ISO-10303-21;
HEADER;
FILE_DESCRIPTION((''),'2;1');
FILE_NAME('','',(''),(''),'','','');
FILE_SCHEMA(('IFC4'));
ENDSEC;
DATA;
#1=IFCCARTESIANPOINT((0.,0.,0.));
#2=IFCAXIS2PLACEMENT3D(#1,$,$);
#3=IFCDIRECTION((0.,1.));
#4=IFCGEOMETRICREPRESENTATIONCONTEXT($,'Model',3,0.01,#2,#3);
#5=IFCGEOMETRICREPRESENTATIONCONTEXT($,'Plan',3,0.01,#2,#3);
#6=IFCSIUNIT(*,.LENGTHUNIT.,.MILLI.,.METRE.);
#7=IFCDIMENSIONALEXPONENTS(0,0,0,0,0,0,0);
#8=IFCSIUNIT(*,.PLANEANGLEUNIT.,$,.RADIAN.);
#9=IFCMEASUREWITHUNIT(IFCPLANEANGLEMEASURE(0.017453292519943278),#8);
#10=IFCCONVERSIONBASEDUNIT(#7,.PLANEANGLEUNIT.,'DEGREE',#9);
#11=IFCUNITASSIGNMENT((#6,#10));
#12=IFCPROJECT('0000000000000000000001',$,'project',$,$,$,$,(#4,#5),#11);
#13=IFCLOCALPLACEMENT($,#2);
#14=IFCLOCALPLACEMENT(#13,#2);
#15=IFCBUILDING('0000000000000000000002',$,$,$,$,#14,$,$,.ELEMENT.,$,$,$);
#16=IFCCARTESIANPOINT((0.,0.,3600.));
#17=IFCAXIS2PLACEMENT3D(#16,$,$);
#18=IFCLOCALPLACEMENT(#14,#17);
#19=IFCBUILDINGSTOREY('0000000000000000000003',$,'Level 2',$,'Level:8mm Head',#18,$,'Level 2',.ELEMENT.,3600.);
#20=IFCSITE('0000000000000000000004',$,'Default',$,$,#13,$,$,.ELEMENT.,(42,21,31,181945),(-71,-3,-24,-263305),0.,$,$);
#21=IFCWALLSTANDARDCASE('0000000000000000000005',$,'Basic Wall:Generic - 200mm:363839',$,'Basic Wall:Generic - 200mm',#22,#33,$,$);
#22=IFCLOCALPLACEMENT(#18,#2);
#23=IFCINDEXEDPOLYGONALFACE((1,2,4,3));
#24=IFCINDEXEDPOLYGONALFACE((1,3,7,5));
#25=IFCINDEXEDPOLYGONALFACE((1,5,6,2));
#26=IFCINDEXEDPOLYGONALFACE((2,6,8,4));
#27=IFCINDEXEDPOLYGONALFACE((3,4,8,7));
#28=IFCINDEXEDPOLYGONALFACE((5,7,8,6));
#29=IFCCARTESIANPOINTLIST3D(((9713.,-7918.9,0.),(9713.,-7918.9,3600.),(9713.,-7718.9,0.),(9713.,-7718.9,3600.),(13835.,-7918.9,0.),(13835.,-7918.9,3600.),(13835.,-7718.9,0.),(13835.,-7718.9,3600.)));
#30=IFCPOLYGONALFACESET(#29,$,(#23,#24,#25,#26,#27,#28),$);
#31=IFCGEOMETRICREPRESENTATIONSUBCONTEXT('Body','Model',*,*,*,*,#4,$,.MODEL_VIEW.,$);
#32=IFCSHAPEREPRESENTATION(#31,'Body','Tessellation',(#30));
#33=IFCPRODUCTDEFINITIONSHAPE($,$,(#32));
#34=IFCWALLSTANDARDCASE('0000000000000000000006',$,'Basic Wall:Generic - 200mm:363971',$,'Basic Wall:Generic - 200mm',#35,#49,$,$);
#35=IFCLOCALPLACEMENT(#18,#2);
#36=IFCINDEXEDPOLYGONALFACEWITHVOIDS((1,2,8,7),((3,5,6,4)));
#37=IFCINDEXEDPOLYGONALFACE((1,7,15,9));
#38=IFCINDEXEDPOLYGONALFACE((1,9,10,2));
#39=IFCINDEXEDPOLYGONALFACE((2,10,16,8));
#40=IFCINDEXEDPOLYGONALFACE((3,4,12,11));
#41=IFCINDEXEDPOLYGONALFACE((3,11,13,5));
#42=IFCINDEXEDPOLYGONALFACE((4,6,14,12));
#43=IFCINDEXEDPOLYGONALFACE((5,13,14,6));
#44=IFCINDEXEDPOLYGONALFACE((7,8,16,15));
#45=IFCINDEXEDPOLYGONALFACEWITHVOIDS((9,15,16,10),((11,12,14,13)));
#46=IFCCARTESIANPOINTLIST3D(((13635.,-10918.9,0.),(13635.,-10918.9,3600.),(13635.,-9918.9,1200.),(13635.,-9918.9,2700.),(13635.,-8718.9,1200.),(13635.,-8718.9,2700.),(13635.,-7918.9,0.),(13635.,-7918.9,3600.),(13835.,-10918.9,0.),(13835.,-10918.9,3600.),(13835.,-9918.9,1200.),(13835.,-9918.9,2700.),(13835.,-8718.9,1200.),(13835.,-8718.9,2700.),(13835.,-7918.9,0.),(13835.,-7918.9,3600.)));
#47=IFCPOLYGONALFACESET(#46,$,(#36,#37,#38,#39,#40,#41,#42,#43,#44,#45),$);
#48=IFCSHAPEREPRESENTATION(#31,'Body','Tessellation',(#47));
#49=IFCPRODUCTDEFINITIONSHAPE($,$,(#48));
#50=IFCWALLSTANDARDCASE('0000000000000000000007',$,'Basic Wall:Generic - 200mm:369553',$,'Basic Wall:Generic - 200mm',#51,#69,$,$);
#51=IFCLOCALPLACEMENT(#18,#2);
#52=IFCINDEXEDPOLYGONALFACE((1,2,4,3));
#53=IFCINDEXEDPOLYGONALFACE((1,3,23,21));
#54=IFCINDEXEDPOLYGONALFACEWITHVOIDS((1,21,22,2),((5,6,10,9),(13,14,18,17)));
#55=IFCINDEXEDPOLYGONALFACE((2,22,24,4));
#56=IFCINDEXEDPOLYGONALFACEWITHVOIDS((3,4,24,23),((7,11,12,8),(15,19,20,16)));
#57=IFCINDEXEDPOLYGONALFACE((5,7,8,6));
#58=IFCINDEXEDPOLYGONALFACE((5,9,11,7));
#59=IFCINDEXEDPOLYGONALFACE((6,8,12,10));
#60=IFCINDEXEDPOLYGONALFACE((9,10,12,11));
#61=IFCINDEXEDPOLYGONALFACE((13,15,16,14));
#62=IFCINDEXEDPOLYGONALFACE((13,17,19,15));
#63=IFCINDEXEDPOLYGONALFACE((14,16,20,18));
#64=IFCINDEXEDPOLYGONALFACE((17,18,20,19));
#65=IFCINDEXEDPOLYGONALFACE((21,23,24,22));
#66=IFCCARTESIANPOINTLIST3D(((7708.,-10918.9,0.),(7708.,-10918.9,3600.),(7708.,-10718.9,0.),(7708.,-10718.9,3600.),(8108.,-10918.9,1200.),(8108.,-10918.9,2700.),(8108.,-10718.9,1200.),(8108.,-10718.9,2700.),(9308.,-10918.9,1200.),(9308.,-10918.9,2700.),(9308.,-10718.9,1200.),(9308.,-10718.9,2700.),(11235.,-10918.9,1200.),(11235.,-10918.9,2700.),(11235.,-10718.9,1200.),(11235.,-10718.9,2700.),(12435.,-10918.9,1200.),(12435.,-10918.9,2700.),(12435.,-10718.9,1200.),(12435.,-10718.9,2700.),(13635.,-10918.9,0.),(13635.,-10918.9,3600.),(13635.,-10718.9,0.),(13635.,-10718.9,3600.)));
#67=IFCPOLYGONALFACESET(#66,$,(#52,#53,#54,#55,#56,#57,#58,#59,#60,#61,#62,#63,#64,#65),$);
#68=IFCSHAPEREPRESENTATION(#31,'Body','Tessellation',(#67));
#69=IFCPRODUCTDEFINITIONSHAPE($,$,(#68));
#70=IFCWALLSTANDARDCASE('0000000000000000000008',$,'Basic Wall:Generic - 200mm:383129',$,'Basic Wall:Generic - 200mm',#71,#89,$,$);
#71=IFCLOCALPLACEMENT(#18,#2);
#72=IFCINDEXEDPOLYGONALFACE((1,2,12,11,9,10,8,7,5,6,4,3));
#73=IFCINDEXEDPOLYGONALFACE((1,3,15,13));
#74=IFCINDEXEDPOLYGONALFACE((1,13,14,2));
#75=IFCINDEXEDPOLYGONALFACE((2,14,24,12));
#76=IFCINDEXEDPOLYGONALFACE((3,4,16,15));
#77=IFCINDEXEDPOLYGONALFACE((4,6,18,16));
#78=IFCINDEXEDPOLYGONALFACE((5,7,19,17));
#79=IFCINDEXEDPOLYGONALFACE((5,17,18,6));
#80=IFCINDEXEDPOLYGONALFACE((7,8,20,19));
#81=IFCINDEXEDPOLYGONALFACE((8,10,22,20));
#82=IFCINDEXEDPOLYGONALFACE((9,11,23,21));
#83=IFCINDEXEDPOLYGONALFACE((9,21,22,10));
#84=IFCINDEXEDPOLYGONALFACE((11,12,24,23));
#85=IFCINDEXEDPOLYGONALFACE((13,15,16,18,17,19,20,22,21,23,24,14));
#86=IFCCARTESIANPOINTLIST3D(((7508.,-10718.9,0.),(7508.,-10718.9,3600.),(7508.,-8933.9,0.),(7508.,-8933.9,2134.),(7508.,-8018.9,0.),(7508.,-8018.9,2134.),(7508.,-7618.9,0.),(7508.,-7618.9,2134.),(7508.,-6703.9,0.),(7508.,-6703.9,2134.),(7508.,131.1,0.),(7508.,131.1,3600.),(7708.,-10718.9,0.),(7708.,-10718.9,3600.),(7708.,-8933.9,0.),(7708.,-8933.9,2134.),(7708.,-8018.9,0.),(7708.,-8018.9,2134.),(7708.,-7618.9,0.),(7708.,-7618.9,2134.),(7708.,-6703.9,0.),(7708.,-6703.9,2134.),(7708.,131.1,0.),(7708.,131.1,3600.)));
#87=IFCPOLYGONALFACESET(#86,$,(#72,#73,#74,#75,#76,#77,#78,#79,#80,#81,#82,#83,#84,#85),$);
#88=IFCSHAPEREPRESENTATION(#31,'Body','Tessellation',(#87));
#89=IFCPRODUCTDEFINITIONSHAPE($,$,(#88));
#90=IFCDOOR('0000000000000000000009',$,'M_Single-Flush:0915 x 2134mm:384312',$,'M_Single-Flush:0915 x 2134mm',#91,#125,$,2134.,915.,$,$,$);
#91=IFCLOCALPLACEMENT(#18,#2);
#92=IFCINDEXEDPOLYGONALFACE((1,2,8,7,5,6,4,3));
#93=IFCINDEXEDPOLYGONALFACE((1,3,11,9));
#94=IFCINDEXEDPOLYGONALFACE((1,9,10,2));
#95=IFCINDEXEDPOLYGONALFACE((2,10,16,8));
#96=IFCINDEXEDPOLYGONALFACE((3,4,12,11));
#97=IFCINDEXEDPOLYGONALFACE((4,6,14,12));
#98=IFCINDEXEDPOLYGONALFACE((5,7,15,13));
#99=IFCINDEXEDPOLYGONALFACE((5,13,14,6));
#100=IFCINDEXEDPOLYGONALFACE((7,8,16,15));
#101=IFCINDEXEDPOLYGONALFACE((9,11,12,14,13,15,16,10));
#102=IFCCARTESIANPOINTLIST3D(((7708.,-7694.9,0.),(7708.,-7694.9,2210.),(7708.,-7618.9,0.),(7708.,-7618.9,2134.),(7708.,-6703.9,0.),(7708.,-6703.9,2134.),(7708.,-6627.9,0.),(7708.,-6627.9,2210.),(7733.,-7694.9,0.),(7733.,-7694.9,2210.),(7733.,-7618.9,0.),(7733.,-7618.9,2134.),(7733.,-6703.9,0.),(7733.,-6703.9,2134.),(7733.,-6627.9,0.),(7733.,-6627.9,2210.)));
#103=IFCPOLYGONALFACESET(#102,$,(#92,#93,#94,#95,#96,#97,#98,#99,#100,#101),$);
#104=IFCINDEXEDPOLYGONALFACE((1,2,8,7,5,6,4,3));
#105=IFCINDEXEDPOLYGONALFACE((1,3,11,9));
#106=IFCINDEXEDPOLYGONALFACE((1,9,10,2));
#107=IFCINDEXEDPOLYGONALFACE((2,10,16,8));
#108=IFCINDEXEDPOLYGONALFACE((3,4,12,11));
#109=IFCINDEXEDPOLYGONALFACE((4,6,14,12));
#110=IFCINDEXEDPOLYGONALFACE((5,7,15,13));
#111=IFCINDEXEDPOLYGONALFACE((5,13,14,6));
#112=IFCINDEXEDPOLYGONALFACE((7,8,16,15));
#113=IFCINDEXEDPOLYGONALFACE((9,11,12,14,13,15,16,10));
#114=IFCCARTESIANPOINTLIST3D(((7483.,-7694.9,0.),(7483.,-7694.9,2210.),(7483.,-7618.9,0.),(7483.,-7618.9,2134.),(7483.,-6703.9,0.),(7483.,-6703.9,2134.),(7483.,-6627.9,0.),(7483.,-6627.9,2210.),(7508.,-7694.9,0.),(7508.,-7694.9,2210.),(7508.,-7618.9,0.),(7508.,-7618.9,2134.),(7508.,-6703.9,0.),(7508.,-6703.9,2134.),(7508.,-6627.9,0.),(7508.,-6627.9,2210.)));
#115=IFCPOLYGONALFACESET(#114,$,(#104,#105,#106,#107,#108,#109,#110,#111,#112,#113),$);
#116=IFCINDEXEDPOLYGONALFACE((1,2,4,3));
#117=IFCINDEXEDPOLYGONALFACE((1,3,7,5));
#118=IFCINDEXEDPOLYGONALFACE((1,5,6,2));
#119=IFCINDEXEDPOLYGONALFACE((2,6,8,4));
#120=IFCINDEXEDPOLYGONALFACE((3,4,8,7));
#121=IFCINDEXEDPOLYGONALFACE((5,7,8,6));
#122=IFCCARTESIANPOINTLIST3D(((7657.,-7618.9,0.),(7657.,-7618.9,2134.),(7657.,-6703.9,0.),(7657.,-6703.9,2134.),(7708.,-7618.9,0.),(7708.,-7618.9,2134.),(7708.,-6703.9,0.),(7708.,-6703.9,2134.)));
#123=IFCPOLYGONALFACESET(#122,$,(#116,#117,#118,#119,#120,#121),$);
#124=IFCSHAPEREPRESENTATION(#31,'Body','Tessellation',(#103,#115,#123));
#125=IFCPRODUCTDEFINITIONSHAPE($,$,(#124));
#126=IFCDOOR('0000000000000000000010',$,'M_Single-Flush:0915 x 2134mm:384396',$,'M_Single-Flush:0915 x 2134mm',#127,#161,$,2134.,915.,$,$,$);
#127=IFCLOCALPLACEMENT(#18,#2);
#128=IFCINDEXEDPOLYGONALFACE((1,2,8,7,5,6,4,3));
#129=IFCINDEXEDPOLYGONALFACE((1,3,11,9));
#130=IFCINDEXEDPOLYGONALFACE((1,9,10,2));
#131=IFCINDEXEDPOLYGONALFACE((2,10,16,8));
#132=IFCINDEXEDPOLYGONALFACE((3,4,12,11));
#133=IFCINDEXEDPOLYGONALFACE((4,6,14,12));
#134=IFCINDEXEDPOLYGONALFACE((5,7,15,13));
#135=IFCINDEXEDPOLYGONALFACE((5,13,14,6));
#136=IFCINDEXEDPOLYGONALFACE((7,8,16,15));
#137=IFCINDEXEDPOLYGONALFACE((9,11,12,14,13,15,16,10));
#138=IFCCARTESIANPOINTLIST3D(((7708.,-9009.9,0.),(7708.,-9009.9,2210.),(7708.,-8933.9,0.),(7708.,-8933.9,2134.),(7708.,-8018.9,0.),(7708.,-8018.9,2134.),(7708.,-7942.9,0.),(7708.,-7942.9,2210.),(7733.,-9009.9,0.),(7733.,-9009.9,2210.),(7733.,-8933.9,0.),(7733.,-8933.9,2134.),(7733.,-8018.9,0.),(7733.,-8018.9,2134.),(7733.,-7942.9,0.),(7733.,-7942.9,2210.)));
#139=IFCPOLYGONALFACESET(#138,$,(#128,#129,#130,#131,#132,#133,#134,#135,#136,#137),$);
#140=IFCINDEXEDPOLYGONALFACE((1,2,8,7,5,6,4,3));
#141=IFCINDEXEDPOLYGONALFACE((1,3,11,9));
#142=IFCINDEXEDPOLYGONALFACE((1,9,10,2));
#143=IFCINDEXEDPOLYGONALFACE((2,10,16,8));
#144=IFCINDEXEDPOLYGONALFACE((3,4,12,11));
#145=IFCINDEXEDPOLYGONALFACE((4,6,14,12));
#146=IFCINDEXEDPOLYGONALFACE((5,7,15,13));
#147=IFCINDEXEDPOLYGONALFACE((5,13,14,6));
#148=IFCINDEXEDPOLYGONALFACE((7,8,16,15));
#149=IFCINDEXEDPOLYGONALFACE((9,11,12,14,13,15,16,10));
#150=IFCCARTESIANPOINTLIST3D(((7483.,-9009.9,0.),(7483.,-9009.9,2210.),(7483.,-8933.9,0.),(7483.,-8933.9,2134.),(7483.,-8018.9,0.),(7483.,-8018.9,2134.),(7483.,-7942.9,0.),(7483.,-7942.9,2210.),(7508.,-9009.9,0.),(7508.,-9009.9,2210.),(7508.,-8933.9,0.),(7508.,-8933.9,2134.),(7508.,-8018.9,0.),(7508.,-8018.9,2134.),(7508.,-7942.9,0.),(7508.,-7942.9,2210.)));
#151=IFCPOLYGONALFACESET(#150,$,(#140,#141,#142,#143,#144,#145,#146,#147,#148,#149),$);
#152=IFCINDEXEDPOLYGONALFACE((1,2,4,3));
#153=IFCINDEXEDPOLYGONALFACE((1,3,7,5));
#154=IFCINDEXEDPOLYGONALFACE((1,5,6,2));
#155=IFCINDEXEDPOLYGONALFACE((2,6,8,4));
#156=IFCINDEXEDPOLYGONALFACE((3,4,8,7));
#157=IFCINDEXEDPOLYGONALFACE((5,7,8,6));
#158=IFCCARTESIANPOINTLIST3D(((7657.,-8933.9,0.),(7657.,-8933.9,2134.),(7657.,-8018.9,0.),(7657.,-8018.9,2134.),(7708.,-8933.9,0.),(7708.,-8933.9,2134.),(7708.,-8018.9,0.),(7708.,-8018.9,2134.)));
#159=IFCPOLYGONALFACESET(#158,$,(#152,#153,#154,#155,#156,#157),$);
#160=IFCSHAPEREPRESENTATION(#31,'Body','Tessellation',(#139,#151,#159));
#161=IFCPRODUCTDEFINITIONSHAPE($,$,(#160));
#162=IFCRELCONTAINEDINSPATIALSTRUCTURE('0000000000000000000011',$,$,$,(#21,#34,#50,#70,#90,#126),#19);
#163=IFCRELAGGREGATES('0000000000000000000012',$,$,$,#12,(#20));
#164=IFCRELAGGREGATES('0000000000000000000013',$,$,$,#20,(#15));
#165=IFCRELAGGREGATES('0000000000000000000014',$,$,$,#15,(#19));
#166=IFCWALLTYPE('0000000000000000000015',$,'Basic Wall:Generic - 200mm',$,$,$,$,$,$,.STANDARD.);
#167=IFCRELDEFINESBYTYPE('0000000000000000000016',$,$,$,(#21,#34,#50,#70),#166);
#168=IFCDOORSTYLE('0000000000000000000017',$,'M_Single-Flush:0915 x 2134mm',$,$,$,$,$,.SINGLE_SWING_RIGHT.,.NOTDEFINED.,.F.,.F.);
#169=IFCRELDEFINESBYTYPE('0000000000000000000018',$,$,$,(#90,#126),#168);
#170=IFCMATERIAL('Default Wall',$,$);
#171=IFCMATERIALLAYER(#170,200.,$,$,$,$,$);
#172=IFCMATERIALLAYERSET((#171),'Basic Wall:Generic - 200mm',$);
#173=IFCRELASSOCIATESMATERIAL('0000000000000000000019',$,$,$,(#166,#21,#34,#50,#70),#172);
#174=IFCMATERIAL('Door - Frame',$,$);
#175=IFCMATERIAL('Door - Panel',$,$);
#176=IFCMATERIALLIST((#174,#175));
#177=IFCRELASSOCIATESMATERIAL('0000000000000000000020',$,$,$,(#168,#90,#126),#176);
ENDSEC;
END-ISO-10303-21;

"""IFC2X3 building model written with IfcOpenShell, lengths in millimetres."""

from ifc_helpers import new_model, entity, si_unit, converted_unit, direction, frame, frame_2d, origin, place, context, subcontext, project, spatial, polyline, rectangle, outline, extrude, source, transform, mapped, material, material_list, layer, layer_set, layer_usage, type_object, type_shapes, element, fill, save


model = new_model("IFC2X3")

# Units and contexts
model_context = context("Model", 3, precision=0.01, world=origin(), true_north=direction((0.0, 1.0)))
plan_context = context("Plan", 3, precision=0.01, world=origin(), true_north=direction((0.0, 1.0)))
body_context = subcontext(model_context, "Body", "Model", "MODEL_VIEW")
ifc_project = project(units=[si_unit("LENGTHUNIT", "METRE", prefix="MILLI"), converted_unit("PLANEANGLEUNIT", "DEGREE", entity("IfcPlaneAngleMeasure", 0.017453292519943278), si_unit("PLANEANGLEUNIT", "RADIAN"), dimensions=[0, 0, 0, 0, 0, 0, 0])], contexts=[model_context, plan_context])

# Site, building, storey
site_placement = place(None, origin())
site = spatial("IfcSite", under=ifc_project, at=site_placement, Name="Default", CompositionType="ELEMENT", RefLatitude=(42, 21, 31, 181945), RefLongitude=(-71, -3, -24, -263305), RefElevation=0.0)
building_placement = place(site_placement, origin())
building = spatial("IfcBuilding", under=site, at=building_placement, CompositionType="ELEMENT")
storey_placement = place(building_placement, frame((0.0, 0.0, 3600.0)))
storey = spatial("IfcBuildingStorey", under=building, at=storey_placement, Name="Level 2", ObjectType="Level:8mm Head", LongName="Level 2", CompositionType="ELEMENT", Elevation=3600.0)

# Wall
ifc_material_1 = material(Name="Default Wall")
ifc_layer = layer(ifc_material_1, 200.0)
ifc_layer_set = layer_set([ifc_layer], Name="Basic Wall:Generic - 200mm")
ifc_layer_usage_1 = layer_usage(ifc_layer_set, "AXIS2", "NEGATIVE", 100.0)
wall_type = type_object("IfcWallType", Name="Basic Wall:Generic - 200mm", PredefinedType="STANDARD", material=ifc_layer_set)
wall_1_placement = place(storey_placement, frame((9713.0, -7818.9, 0.0)))
element("IfcWallStandardCase", 1, at=wall_1_placement, inside=storey, type_object=wall_type, material=ifc_layer_usage_1, Name="Basic Wall:Generic - 200mm:363839", ObjectType="Basic Wall:Generic - 200mm", context=body_context, shape_type="SweptSolid", body=[
    extrude(rectangle(XDim=4122.0, YDim=200.0, at=frame_2d((2061.0, 0.0), x_axis=(-1.0, 0.0))), origin(), (0.0, 0.0, 1.0), 3600.0),
])

# Wall, opening
ifc_layer_usage_2 = layer_usage(ifc_layer_set, "AXIS2", "NEGATIVE", 100.0)
wall_2_placement = place(storey_placement, frame((13735.0, -7918.9, 0.0), z_axis=(0.0, 0.0, 1.0), x_axis=(0.0, -1.0, 0.0)))
wall_2 = element("IfcWallStandardCase", 2, at=wall_2_placement, inside=storey, type_object=wall_type, material=ifc_layer_usage_2, Name="Basic Wall:Generic - 200mm:363971", ObjectType="Basic Wall:Generic - 200mm", context=body_context, shape_type="SweptSolid", body=[
    extrude(rectangle(XDim=3000.0, YDim=200.0, at=frame_2d((1500.0, 0.0), x_axis=(-1.0, 0.0))), origin(), (0.0, 0.0, 1.0), 3600.0),
])
opening_1_placement = place(wall_2_placement, frame((800.0, -100.0, 1200.0)))
element("IfcOpeningElement", 3, at=opening_1_placement, cuts=wall_2, ObjectType="Opening", context=body_context, shape_type="SweptSolid", body=[
    extrude(rectangle(XDim=1500.0, YDim=1200.0, at=frame_2d((750.0, 600.0), x_axis=(-1.0, 0.0))), frame((0.0, 0.0, 0.0), z_axis=(0.0, 1.0, 0.0), x_axis=(0.0, 0.0, 1.0)), (0.0, 0.0, 1.0), 200.0),
])

# Wall, openings
ifc_layer_usage_3 = layer_usage(ifc_layer_set, "AXIS2", "NEGATIVE", 100.0)
wall_3_placement = place(storey_placement, frame((7708.0, -10818.9, 0.0)))
wall_3 = element("IfcWallStandardCase", 4, at=wall_3_placement, inside=storey, type_object=wall_type, material=ifc_layer_usage_3, Name="Basic Wall:Generic - 200mm:369553", ObjectType="Basic Wall:Generic - 200mm", context=body_context, shape_type="SweptSolid", body=[
    extrude(rectangle(XDim=5927.0, YDim=200.0, at=frame_2d((2963.5, 0.0), x_axis=(-1.0, 0.0))), origin(), (0.0, 0.0, 1.0), 3600.0),
])
opening_2_placement = place(wall_3_placement, frame((1600.0, 100.0, 1200.0)))
element("IfcOpeningElement", 5, at=opening_2_placement, cuts=wall_3, ObjectType="Opening", context=body_context, shape_type="SweptSolid", body=[
    extrude(rectangle(XDim=1500.0, YDim=1200.0, at=frame_2d((750.0, 600.0), x_axis=(-1.0, 0.0))), frame((0.0, 0.0, 0.0), z_axis=(0.0, -1.0, 0.0), x_axis=(0.0, 0.0, 1.0)), (0.0, 0.0, 1.0), 200.0),
])
opening_3_placement = place(wall_3_placement, frame((4727.0, 100.0, 1200.0)))
element("IfcOpeningElement", 6, at=opening_3_placement, cuts=wall_3, ObjectType="Opening", context=body_context, shape_type="SweptSolid", body=[
    extrude(rectangle(XDim=1500.0, YDim=1200.0, at=frame_2d((750.0, 600.0), x_axis=(-1.0, 0.0))), frame((0.0, 0.0, 0.0), z_axis=(0.0, -1.0, 0.0), x_axis=(0.0, 0.0, 1.0)), (0.0, 0.0, 1.0), 200.0),
])

# Wall, openings, doors
ifc_layer_usage_4 = layer_usage(ifc_layer_set, "AXIS2", "NEGATIVE", 100.0)
wall_4_placement = place(storey_placement, frame((7608.0, -10718.9, 0.0), z_axis=(0.0, 0.0, 1.0), x_axis=(0.0, 1.0, 0.0)))
wall_4 = element("IfcWallStandardCase", 7, at=wall_4_placement, inside=storey, type_object=wall_type, material=ifc_layer_usage_4, Name="Basic Wall:Generic - 200mm:383129", ObjectType="Basic Wall:Generic - 200mm", context=body_context, shape_type="SweptSolid", body=[
    extrude(rectangle(XDim=10850.0, YDim=200.0, at=frame_2d((5425.0, 0.0), x_axis=(1.0, 0.0))), origin(), (0.0, 0.0, 1.0), 3600.0),
])
opening_4_placement = place(wall_4_placement, frame((4015.0, 100.0, 0.0)))
opening_4 = element("IfcOpeningElement", 8, at=opening_4_placement, cuts=wall_4, ObjectType="Opening", context=body_context, shape_type="SweptSolid", body=[
    extrude(rectangle(XDim=915.0, YDim=2134.0, at=frame_2d((1067.0, 457.5), x_axis=(0.0, 1.0))), frame((0.0, 0.0, 0.0), z_axis=(0.0, -1.0, 0.0), x_axis=(0.0, 0.0, 1.0)), (0.0, 0.0, 1.0), 200.0),
])
opening_5_placement = place(wall_4_placement, frame((2700.0, 100.0, 0.0)))
opening_5 = element("IfcOpeningElement", 9, at=opening_5_placement, cuts=wall_4, ObjectType="Opening", context=body_context, shape_type="SweptSolid", body=[
    extrude(rectangle(XDim=915.0, YDim=2134.0, at=frame_2d((1067.0, 457.5), x_axis=(0.0, 1.0))), frame((0.0, 0.0, 0.0), z_axis=(0.0, -1.0, 0.0), x_axis=(0.0, 0.0, 1.0)), (0.0, 0.0, 1.0), 200.0),
])
ifc_material_2 = material(Name="Door - Frame")
ifc_material_3 = material(Name="Door - Panel")
ifc_material_list_1 = material_list([ifc_material_2, ifc_material_3])
door_style = type_object("IfcDoorStyle", Name="M_Single-Flush:0915 x 2134mm", ConstructionType="NOTDEFINED", OperationType="SINGLE_SWING_RIGHT", ParameterTakesPrecedence=False, Sizeable=False, material=ifc_material_list_1)
shared_shape_1 = source(origin(), body_context, "Body", "SweptSolid", [
    extrude(outline(polyline([(-533.5, -1124.0), (533.5, -1124.0), (533.5, 1086.0), (457.5, 1086.0), (457.5, -1048.0), (-457.5, -1048.0), (-457.5, 1086.0), (-533.5, 1086.0), (-533.5, -1124.0)])), frame((457.5, 200.0, 1086.0), z_axis=(0.0, 1.0, 0.0), x_axis=(1.0, 0.0, 0.0)), (0.0, 0.0, 1.0), 25.0),
    extrude(outline(polyline([(-1124.0, -533.5), (1086.0, -533.5), (1086.0, -457.5), (-1048.0, -457.5), (-1048.0, 457.5), (1086.0, 457.5), (1086.0, 533.5), (-1124.0, 533.5), (-1124.0, -533.5)])), frame((457.5, -25.0, 1086.0), z_axis=(0.0, 1.0, 0.0), x_axis=(0.0, 0.0, -1.0)), (0.0, 0.0, 1.0), 25.0),
    extrude(rectangle(XDim=51.0, YDim=915.0, at=frame_2d((0.0, 0.0), x_axis=(1.0, 0.0))), frame((457.5, 174.5, 0.0), z_axis=(0.0, 0.0, 1.0), x_axis=(0.0, 1.0, 0.0)), (0.0, 0.0, 1.0), 2134.0),
])
type_shapes(door_style, [shared_shape_1])
door_1_placement = place(opening_4_placement, frame((0.0, 0.0, 0.0), z_axis=(0.0, 0.0, 1.0), x_axis=(-1.0, 0.0, 0.0)))
door_1 = element("IfcDoor", 10, at=door_1_placement, inside=storey, type_object=door_style, material=ifc_material_list_1, Name="M_Single-Flush:0915 x 2134mm:384312", ObjectType="M_Single-Flush:0915 x 2134mm", OverallHeight=2134.0, OverallWidth=915.0, context=body_context, shape_type="MappedRepresentation", body=[
    mapped(shared_shape_1, transform((0.0, 0.0, 0.0), scale=1.0)),
])
fill(opening_4, door_1)
door_2_placement = place(opening_5_placement, frame((0.0, 0.0, 0.0), z_axis=(0.0, 0.0, 1.0), x_axis=(-1.0, 0.0, 0.0)))
door_2 = element("IfcDoor", 11, at=door_2_placement, inside=storey, type_object=door_style, material=ifc_material_list_1, Name="M_Single-Flush:0915 x 2134mm:384396", ObjectType="M_Single-Flush:0915 x 2134mm", OverallHeight=2134.0, OverallWidth=915.0, context=body_context, shape_type="MappedRepresentation", body=[
    mapped(shared_shape_1, transform((0.0, 0.0, 0.0), scale=1.0)),
])
fill(opening_5, door_2)

save(model, "model.ifc")
